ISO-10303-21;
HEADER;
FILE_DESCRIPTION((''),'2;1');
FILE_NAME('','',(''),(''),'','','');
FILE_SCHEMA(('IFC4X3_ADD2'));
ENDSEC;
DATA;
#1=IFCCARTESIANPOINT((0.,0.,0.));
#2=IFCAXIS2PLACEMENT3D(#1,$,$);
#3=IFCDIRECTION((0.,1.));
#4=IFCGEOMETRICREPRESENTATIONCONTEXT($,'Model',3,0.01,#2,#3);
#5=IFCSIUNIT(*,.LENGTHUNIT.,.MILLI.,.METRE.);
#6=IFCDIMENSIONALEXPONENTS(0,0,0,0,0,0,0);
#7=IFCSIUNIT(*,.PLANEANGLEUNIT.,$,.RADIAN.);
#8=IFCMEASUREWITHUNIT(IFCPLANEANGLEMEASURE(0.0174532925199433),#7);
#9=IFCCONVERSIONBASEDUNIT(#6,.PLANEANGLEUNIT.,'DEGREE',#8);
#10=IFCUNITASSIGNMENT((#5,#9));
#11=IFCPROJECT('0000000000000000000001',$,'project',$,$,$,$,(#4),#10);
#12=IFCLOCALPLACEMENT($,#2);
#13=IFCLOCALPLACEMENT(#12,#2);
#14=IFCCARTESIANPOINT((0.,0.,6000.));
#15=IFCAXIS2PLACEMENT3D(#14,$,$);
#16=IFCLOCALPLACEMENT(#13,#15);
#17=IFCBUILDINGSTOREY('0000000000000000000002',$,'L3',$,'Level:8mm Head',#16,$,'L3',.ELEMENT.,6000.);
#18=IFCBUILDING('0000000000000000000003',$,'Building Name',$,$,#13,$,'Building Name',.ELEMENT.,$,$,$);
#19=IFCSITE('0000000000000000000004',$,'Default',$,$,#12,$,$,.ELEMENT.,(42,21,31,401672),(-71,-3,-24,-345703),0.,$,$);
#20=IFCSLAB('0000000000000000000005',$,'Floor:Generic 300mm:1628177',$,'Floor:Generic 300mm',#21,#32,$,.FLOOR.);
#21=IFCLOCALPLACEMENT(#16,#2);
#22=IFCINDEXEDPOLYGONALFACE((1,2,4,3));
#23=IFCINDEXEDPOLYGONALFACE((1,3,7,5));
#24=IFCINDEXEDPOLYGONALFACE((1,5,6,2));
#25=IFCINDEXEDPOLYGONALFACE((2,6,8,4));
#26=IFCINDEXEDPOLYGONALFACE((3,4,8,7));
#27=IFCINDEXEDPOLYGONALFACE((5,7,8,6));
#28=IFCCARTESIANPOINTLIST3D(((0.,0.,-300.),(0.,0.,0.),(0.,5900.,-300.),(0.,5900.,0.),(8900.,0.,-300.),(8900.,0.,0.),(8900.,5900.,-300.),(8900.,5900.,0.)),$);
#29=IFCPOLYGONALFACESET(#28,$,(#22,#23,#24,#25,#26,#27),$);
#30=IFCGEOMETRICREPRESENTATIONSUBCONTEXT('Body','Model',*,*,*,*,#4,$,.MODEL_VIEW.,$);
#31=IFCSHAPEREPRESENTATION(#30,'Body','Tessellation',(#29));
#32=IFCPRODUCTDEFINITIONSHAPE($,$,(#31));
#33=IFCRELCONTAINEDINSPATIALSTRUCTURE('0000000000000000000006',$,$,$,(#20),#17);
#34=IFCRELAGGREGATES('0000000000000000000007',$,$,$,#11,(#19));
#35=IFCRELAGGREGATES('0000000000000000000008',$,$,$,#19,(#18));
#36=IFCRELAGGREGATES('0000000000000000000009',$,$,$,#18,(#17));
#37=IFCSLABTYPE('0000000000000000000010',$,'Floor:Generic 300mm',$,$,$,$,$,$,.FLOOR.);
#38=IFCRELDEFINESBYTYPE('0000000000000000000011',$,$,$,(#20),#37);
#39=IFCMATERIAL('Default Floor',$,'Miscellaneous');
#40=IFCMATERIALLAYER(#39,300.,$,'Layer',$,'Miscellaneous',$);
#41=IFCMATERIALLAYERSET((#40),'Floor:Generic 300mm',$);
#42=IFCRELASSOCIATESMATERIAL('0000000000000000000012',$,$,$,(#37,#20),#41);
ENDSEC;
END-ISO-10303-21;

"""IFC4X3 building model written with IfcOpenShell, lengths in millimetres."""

from ifc_helpers import new_model, entity, si_unit, converted_unit, direction, frame, frame_2d, origin, place, context, subcontext, project, spatial, rectangle, extrude, material, layer, layer_set, layer_usage, type_object, element, save


model = new_model("IFC4X3")

# Units and contexts
model_context = context("Model", 3, precision=0.01, world=origin(), true_north=direction((0.0, 1.0)))
body_context = subcontext(model_context, "Body", "Model", "MODEL_VIEW")
ifc_project = project(units=[si_unit("LENGTHUNIT", "METRE", prefix="MILLI"), converted_unit("PLANEANGLEUNIT", "DEGREE", entity("IfcPlaneAngleMeasure", 0.0174532925199433), si_unit("PLANEANGLEUNIT", "RADIAN"), dimensions=[0, 0, 0, 0, 0, 0, 0])], contexts=[model_context])

# Site, building, storey
site_placement = place(None, origin())
site = spatial("IfcSite", under=ifc_project, at=site_placement, Name="Default", CompositionType="ELEMENT", RefLatitude=(42, 21, 31, 401672), RefLongitude=(-71, -3, -24, -345703), RefElevation=0.0)
building_placement = place(site_placement, origin())
building = spatial("IfcBuilding", under=site, at=building_placement, Name="Building Name", LongName="Building Name", CompositionType="ELEMENT")
storey_placement = place(building_placement, frame((0.0, 0.0, 6000.0)))
storey = spatial("IfcBuildingStorey", under=building, at=storey_placement, Name="L3", ObjectType="Level:8mm Head", LongName="L3", CompositionType="ELEMENT", Elevation=6000.0)

# Slab
ifc_material = material(Name="Default Floor", Category="Miscellaneous")
ifc_layer = layer(ifc_material, 300.0, Name="Layer", Category="Miscellaneous")
ifc_layer_set = layer_set([ifc_layer], Name="Floor:Generic 300mm")
ifc_layer_usage = layer_usage(ifc_layer_set, "AXIS3", "POSITIVE", 0.0)
slab_type = type_object("IfcSlabType", Name="Floor:Generic 300mm", PredefinedType="FLOOR", material=ifc_layer_set)
slab_placement = place(storey_placement, origin())
element("IfcSlab", 1, at=slab_placement, inside=storey, type_object=slab_type, material=ifc_layer_usage, Name="Floor:Generic 300mm:1628177", ObjectType="Floor:Generic 300mm", PredefinedType="FLOOR", context=body_context, shape_type="SweptSolid", body=[
    extrude(rectangle(XDim=5900.0, YDim=8900.0, at=frame_2d((0.0, 0.0), x_axis=(1.0, 0.0))), frame((4450.0, 2950.0, 0.0), z_axis=(0.0, 0.0, -1.0), x_axis=(0.0, 1.0, 0.0)), (0.0, 0.0, 1.0), 300.0),
])

save(model, "model.ifc")
